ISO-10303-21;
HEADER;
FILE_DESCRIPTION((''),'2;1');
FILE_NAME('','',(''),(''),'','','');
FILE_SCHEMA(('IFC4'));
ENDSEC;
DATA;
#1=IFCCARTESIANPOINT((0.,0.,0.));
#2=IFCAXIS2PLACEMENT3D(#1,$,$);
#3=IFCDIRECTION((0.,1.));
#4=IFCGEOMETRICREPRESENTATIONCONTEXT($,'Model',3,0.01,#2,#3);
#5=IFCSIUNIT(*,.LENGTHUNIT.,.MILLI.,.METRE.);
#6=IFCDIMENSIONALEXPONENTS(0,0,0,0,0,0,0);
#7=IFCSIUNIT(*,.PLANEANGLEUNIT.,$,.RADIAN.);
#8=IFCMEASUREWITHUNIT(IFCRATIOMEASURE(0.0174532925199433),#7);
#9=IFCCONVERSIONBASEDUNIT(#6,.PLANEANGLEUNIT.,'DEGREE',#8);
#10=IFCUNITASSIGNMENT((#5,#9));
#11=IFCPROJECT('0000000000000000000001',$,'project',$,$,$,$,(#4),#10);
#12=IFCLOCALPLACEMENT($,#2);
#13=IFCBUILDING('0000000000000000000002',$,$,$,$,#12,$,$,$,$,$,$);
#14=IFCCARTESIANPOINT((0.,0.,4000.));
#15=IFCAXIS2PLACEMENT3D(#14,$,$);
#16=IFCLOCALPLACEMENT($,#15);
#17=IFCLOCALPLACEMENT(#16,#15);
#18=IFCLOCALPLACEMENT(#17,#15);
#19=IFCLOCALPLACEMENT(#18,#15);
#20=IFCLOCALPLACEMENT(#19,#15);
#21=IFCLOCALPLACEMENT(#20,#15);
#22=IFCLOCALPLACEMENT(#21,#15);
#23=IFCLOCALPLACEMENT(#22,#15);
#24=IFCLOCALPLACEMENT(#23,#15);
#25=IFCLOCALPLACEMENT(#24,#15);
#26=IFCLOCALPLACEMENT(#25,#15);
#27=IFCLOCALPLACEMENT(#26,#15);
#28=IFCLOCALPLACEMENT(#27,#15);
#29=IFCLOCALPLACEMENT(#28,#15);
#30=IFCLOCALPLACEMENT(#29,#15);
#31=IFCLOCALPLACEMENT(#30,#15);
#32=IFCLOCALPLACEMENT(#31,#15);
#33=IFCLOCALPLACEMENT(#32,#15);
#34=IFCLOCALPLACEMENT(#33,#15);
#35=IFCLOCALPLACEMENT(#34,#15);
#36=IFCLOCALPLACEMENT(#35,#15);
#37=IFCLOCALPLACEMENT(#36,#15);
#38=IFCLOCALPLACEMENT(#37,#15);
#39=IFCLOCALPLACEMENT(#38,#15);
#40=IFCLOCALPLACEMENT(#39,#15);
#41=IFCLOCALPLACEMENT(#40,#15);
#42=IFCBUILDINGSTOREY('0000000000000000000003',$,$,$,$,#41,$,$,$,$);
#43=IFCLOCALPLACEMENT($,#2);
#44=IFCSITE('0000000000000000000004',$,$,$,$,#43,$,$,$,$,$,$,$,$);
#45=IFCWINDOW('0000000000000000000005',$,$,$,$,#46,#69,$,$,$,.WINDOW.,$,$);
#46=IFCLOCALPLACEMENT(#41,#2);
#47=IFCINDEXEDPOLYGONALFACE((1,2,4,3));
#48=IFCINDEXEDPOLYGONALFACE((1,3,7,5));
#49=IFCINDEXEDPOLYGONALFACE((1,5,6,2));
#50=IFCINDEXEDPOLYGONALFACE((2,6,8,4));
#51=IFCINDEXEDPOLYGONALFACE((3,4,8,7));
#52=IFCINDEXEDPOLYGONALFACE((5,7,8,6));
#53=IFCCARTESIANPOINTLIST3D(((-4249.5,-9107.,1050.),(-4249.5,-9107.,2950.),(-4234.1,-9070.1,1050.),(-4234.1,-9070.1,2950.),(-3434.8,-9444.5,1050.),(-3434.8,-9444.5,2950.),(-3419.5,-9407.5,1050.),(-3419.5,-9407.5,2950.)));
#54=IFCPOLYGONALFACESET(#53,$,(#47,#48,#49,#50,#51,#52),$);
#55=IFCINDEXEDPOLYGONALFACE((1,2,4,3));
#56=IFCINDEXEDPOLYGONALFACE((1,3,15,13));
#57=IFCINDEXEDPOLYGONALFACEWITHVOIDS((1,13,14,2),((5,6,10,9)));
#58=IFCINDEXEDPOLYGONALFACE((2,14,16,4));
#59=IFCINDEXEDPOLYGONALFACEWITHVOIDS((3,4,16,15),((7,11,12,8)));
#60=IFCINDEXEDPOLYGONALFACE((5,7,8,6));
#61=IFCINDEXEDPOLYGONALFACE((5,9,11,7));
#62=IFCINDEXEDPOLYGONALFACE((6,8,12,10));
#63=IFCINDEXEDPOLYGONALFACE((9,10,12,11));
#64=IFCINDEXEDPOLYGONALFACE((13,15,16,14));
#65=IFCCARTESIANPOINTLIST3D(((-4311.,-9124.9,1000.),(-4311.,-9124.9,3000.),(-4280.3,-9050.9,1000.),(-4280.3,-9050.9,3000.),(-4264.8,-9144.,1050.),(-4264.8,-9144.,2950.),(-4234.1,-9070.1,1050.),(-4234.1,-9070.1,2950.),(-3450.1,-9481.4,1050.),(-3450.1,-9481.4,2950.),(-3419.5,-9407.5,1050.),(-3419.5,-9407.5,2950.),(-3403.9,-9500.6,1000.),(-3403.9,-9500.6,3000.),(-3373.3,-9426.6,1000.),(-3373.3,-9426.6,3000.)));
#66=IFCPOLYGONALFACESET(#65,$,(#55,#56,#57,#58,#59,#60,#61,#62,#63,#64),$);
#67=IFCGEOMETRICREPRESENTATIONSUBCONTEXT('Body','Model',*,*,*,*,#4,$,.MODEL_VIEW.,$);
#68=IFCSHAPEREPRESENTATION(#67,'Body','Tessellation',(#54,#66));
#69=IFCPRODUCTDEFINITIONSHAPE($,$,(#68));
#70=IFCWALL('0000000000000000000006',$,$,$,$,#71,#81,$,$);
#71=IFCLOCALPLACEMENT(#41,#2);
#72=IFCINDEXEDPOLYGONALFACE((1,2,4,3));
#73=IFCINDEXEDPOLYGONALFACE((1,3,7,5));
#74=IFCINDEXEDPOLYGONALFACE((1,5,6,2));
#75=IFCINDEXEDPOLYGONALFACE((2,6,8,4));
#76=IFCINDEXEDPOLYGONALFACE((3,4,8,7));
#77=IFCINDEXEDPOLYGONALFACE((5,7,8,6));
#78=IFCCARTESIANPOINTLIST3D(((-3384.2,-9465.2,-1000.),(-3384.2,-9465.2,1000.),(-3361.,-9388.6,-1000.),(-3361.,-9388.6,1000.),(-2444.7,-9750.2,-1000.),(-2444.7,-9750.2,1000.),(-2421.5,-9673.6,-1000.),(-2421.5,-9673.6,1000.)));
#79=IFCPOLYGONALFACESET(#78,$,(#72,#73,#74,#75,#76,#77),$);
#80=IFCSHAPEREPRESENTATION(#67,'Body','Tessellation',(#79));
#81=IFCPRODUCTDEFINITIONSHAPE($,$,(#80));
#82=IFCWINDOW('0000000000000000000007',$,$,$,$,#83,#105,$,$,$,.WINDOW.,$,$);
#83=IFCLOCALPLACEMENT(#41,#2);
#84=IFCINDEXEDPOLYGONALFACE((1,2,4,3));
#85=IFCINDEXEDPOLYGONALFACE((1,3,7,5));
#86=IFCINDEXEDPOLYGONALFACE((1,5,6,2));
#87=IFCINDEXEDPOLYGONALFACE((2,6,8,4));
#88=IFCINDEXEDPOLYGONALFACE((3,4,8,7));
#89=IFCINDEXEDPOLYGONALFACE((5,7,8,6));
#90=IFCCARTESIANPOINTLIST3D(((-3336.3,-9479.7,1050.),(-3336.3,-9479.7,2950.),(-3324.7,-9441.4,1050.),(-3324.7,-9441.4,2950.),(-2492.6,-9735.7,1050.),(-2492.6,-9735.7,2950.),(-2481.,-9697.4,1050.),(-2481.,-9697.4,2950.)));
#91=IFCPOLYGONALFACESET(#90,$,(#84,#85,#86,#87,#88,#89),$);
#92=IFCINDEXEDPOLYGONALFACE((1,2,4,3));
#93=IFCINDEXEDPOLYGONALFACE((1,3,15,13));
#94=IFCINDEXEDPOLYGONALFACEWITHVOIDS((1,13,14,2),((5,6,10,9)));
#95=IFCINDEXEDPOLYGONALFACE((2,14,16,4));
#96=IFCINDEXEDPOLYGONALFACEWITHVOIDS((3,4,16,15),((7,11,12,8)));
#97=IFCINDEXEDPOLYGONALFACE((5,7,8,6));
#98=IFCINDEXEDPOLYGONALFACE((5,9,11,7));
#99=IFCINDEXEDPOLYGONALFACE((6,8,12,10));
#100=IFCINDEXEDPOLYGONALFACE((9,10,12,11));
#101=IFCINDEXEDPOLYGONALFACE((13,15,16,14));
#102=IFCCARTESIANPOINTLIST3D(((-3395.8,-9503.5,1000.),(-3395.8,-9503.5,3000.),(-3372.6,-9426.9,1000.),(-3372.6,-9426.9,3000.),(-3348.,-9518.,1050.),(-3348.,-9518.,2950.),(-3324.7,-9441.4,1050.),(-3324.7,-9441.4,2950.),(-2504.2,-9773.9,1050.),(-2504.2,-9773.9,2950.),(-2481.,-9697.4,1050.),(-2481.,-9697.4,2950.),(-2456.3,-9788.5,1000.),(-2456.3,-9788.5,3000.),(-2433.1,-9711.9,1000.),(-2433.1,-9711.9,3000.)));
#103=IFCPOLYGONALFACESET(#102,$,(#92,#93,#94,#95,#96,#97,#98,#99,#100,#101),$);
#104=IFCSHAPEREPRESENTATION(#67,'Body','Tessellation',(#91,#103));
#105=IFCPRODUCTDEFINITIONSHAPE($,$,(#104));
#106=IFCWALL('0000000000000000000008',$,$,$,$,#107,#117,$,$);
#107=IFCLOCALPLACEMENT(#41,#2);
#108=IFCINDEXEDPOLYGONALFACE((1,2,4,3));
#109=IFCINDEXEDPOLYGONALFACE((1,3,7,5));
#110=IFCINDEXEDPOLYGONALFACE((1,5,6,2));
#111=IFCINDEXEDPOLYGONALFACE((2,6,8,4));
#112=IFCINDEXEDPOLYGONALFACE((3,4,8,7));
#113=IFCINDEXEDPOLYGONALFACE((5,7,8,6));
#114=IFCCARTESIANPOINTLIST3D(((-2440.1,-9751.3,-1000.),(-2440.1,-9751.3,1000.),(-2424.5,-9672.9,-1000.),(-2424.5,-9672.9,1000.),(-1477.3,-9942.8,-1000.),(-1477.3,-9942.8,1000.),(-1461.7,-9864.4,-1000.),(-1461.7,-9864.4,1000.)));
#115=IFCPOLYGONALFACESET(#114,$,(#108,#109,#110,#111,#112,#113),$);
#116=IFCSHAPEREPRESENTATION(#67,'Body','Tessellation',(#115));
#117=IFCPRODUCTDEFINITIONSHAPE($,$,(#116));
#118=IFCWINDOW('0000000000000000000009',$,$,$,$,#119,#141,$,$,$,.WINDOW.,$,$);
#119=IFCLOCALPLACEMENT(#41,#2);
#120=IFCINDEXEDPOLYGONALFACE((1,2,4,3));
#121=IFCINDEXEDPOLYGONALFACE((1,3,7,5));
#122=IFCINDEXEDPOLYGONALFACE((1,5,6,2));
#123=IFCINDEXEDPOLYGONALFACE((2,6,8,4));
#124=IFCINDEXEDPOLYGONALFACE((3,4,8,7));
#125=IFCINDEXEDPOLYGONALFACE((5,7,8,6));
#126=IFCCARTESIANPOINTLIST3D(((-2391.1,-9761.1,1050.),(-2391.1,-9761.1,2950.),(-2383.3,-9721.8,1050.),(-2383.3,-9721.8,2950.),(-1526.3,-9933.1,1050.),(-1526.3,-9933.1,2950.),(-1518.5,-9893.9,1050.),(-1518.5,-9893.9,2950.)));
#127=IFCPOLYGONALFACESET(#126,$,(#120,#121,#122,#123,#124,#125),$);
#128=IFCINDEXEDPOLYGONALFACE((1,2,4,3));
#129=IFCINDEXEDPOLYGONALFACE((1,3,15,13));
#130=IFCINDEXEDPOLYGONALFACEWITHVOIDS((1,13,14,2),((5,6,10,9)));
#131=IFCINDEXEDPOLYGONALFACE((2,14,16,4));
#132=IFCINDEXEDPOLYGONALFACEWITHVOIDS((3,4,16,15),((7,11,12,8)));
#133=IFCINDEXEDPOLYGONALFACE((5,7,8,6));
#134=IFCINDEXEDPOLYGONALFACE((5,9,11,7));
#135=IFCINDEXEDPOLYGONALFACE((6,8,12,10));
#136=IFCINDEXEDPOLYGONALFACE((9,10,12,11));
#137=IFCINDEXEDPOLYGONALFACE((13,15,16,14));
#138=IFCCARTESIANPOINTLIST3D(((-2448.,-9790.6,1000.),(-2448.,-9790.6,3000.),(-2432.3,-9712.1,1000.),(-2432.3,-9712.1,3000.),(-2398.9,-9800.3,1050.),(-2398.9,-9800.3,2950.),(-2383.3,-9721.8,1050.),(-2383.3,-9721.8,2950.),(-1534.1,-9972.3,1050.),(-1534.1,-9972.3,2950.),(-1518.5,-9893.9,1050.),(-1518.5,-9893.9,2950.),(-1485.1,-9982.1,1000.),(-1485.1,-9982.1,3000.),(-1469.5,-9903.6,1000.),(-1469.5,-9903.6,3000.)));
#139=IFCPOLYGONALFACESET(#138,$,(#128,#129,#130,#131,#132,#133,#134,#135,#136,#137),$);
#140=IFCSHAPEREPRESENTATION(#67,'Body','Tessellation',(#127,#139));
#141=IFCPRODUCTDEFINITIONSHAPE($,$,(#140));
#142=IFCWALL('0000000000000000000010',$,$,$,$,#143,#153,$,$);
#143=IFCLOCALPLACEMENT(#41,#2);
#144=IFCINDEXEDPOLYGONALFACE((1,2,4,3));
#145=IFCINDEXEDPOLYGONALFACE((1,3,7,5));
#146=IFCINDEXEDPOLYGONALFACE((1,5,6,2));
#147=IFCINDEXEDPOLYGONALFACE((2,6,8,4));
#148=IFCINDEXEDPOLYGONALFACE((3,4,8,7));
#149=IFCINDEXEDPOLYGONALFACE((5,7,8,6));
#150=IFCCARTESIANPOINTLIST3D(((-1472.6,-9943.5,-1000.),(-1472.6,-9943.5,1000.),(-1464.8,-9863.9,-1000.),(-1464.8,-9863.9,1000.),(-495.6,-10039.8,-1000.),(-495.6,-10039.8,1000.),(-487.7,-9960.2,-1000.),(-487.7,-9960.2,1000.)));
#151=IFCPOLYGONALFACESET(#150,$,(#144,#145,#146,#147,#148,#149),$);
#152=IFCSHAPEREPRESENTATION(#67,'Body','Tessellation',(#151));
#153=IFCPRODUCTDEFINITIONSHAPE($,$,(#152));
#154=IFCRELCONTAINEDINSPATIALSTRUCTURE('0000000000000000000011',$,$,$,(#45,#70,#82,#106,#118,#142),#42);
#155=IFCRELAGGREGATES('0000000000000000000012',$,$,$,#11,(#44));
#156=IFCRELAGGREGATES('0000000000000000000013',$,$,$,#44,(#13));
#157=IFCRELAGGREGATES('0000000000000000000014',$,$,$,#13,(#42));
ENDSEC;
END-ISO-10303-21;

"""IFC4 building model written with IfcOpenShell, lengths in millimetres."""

from ifc_helpers import new_model, entity, si_unit, converted_unit, direction, frame, origin, origin_2d, place, context, subcontext, project, spatial, rectangle, extrude, element, save


model = new_model("IFC4")

# Units and contexts
model_context = context("Model", 3, precision=0.01, world=origin(), true_north=direction((0.0, 1.0)))
body_context = subcontext(model_context, "Body", "Model", "MODEL_VIEW")
ifc_project = project(units=[si_unit("LENGTHUNIT", "METRE", prefix="MILLI"), converted_unit("PLANEANGLEUNIT", "DEGREE", entity("IfcRatioMeasure", 0.0174532925199433), si_unit("PLANEANGLEUNIT", "RADIAN"), dimensions=[0, 0, 0, 0, 0, 0, 0])], contexts=[model_context])

# Site, building, storey
site_placement = place(None, origin())
site = spatial("IfcSite", under=ifc_project, at=site_placement)
building_placement = place(None, origin())
building = spatial("IfcBuilding", under=site, at=building_placement)
placement_1 = place(None, frame((0.0, 0.0, 4000.0)))
placement_2 = place(placement_1, frame((0.0, 0.0, 4000.0)))
placement_3 = place(placement_2, frame((0.0, 0.0, 4000.0)))
placement_4 = place(placement_3, frame((0.0, 0.0, 4000.0)))
placement_5 = place(placement_4, frame((0.0, 0.0, 4000.0)))
placement_6 = place(placement_5, frame((0.0, 0.0, 4000.0)))
placement_7 = place(placement_6, frame((0.0, 0.0, 4000.0)))
placement_8 = place(placement_7, frame((0.0, 0.0, 4000.0)))
placement_9 = place(placement_8, frame((0.0, 0.0, 4000.0)))
placement_10 = place(placement_9, frame((0.0, 0.0, 4000.0)))
placement_11 = place(placement_10, frame((0.0, 0.0, 4000.0)))
placement_12 = place(placement_11, frame((0.0, 0.0, 4000.0)))
placement_13 = place(placement_12, frame((0.0, 0.0, 4000.0)))
placement_14 = place(placement_13, frame((0.0, 0.0, 4000.0)))
placement_15 = place(placement_14, frame((0.0, 0.0, 4000.0)))
placement_16 = place(placement_15, frame((0.0, 0.0, 4000.0)))
placement_17 = place(placement_16, frame((0.0, 0.0, 4000.0)))
placement_18 = place(placement_17, frame((0.0, 0.0, 4000.0)))
placement_19 = place(placement_18, frame((0.0, 0.0, 4000.0)))
placement_20 = place(placement_19, frame((0.0, 0.0, 4000.0)))
placement_21 = place(placement_20, frame((0.0, 0.0, 4000.0)))
placement_22 = place(placement_21, frame((0.0, 0.0, 4000.0)))
placement_23 = place(placement_22, frame((0.0, 0.0, 4000.0)))
placement_24 = place(placement_23, frame((0.0, 0.0, 4000.0)))
placement_25 = place(placement_24, frame((0.0, 0.0, 4000.0)))
storey_placement = place(placement_25, frame((0.0, 0.0, 4000.0)))
storey = spatial("IfcBuildingStorey", under=building, at=storey_placement)

# Shared definitions
cartesian_point_1 = entity("IfcCartesianPoint", [-440.9, -950.0])
shared_polyline = entity("IfcPolyline", [cartesian_point_1, entity("IfcCartesianPoint", [-440.9, 950.0]), entity("IfcCartesianPoint", [-440.9, 950.0]), entity("IfcCartesianPoint", [440.9, 950.0]), entity("IfcCartesianPoint", [440.9, 950.0]), entity("IfcCartesianPoint", [440.9, -950.0]), entity("IfcCartesianPoint", [440.9, -950.0]), entity("IfcCartesianPoint", [-440.9, -950.0]), cartesian_point_1])

# Window
window_1_placement = place(storey_placement, frame((-3826.8, -9238.8, 2000.0), z_axis=(0.0, 0.0, 1.0), x_axis=(9238.794759, -3826.835691, 0.0)))
cartesian_point_2 = entity("IfcCartesianPoint", [-490.9, -1000.0])
element("IfcWindow", 1, at=window_1_placement, inside=storey, PredefinedType="WINDOW", context=body_context, shape_type="SweptSolid", body=[
    entity("IfcExtrudedAreaSolid", entity("IfcArbitraryClosedProfileDef", "AREA", None, shared_polyline), entity("IfcAxis2Placement3D", entity("IfcCartesianPoint", [0.0, 0.0, 0.0]), entity("IfcDirection", [0.0, -1.0, 0.0]), entity("IfcDirection", [1.0, 0.0, 0.0])), entity("IfcDirection", [0.0, 0.0, 1.0]), 40.0),
    entity("IfcExtrudedAreaSolid", entity("IfcArbitraryProfileDefWithVoids", "AREA", None, entity("IfcPolyline", [cartesian_point_2, entity("IfcCartesianPoint", [-490.9, 1000.0]), entity("IfcCartesianPoint", [-490.9, 1000.0]), entity("IfcCartesianPoint", [490.9, 1000.0]), entity("IfcCartesianPoint", [490.9, 1000.0]), entity("IfcCartesianPoint", [490.9, -1000.0]), entity("IfcCartesianPoint", [490.9, -1000.0]), entity("IfcCartesianPoint", [-490.9, -1000.0]), cartesian_point_2]), [shared_polyline]), entity("IfcAxis2Placement3D", entity("IfcCartesianPoint", [0.0, 0.0, 0.0]), entity("IfcDirection", [0.0, -1.0, 0.0]), entity("IfcDirection", [1.0, 0.0, 0.0])), entity("IfcDirection", [0.0, 0.0, 1.0]), 80.0),
])

# Wall
wall_1_placement = place(storey_placement, frame((-2902.8, -9569.4, -1000.0), z_axis=(0.0, 0.0, 1.0), x_axis=(9569.403736, -2902.845525, 0.0)))
element("IfcWall", 2, at=wall_1_placement, inside=storey, context=body_context, shape_type="SweptSolid", body=[
    extrude(rectangle(XDim=981.7, YDim=80.0, at=origin_2d()), origin(), (0.0, 0.0, 1.0), 2000.0),
])

# Window
window_2_placement = place(storey_placement, frame((-2902.8, -9569.4, 2000.0), z_axis=(0.0, 0.0, 1.0), x_axis=(9569.403736, -2902.845525, 0.0)))
cartesian_point_3 = entity("IfcCartesianPoint", [-490.9, -1000.0])
element("IfcWindow", 3, at=window_2_placement, inside=storey, PredefinedType="WINDOW", context=body_context, shape_type="SweptSolid", body=[
    entity("IfcExtrudedAreaSolid", entity("IfcArbitraryClosedProfileDef", "AREA", None, shared_polyline), entity("IfcAxis2Placement3D", entity("IfcCartesianPoint", [0.0, 0.0, 0.0]), entity("IfcDirection", [0.0, -1.0, 0.0]), entity("IfcDirection", [1.0, 0.0, 0.0])), entity("IfcDirection", [0.0, 0.0, 1.0]), 40.0),
    entity("IfcExtrudedAreaSolid", entity("IfcArbitraryProfileDefWithVoids", "AREA", None, entity("IfcPolyline", [cartesian_point_3, entity("IfcCartesianPoint", [-490.9, 1000.0]), entity("IfcCartesianPoint", [-490.9, 1000.0]), entity("IfcCartesianPoint", [490.9, 1000.0]), entity("IfcCartesianPoint", [490.9, 1000.0]), entity("IfcCartesianPoint", [490.9, -1000.0]), entity("IfcCartesianPoint", [490.9, -1000.0]), entity("IfcCartesianPoint", [-490.9, -1000.0]), cartesian_point_3]), [shared_polyline]), entity("IfcAxis2Placement3D", entity("IfcCartesianPoint", [0.0, 0.0, 0.0]), entity("IfcDirection", [0.0, -1.0, 0.0]), entity("IfcDirection", [1.0, 0.0, 0.0])), entity("IfcDirection", [0.0, 0.0, 1.0]), 80.0),
])

# Wall
wall_2_placement = place(storey_placement, frame((-1950.9, -9807.9, -1000.0), z_axis=(0.0, 0.0, 1.0), x_axis=(9807.852671, -1950.903888, 0.0)))
element("IfcWall", 4, at=wall_2_placement, inside=storey, context=body_context, shape_type="SweptSolid", body=[
    extrude(rectangle(XDim=981.7, YDim=80.0, at=origin_2d()), origin(), (0.0, 0.0, 1.0), 2000.0),
])

# Window
window_3_placement = place(storey_placement, frame((-1950.9, -9807.9, 2000.0), z_axis=(0.0, 0.0, 1.0), x_axis=(9807.852671, -1950.903888, 0.0)))
cartesian_point_4 = entity("IfcCartesianPoint", [-490.9, -1000.0])
element("IfcWindow", 5, at=window_3_placement, inside=storey, PredefinedType="WINDOW", context=body_context, shape_type="SweptSolid", body=[
    entity("IfcExtrudedAreaSolid", entity("IfcArbitraryClosedProfileDef", "AREA", None, shared_polyline), entity("IfcAxis2Placement3D", entity("IfcCartesianPoint", [0.0, 0.0, 0.0]), entity("IfcDirection", [0.0, -1.0, 0.0]), entity("IfcDirection", [1.0, 0.0, 0.0])), entity("IfcDirection", [0.0, 0.0, 1.0]), 40.0),
    entity("IfcExtrudedAreaSolid", entity("IfcArbitraryProfileDefWithVoids", "AREA", None, entity("IfcPolyline", [cartesian_point_4, entity("IfcCartesianPoint", [-490.9, 1000.0]), entity("IfcCartesianPoint", [-490.9, 1000.0]), entity("IfcCartesianPoint", [490.9, 1000.0]), entity("IfcCartesianPoint", [490.9, 1000.0]), entity("IfcCartesianPoint", [490.9, -1000.0]), entity("IfcCartesianPoint", [490.9, -1000.0]), entity("IfcCartesianPoint", [-490.9, -1000.0]), cartesian_point_4]), [shared_polyline]), entity("IfcAxis2Placement3D", entity("IfcCartesianPoint", [0.0, 0.0, 0.0]), entity("IfcDirection", [0.0, -1.0, 0.0]), entity("IfcDirection", [1.0, 0.0, 0.0])), entity("IfcDirection", [0.0, 0.0, 1.0]), 80.0),
])

# Wall
wall_3_placement = place(storey_placement, frame((-980.2, -9951.8, -1000.0), z_axis=(0.0, 0.0, 1.0), x_axis=(9951.847473, -980.16931, 0.0)))
element("IfcWall", 6, at=wall_3_placement, inside=storey, context=body_context, shape_type="SweptSolid", body=[
    extrude(rectangle(XDim=981.7, YDim=80.0, at=origin_2d()), origin(), (0.0, 0.0, 1.0), 2000.0),
])

save(model, "model.ifc")
